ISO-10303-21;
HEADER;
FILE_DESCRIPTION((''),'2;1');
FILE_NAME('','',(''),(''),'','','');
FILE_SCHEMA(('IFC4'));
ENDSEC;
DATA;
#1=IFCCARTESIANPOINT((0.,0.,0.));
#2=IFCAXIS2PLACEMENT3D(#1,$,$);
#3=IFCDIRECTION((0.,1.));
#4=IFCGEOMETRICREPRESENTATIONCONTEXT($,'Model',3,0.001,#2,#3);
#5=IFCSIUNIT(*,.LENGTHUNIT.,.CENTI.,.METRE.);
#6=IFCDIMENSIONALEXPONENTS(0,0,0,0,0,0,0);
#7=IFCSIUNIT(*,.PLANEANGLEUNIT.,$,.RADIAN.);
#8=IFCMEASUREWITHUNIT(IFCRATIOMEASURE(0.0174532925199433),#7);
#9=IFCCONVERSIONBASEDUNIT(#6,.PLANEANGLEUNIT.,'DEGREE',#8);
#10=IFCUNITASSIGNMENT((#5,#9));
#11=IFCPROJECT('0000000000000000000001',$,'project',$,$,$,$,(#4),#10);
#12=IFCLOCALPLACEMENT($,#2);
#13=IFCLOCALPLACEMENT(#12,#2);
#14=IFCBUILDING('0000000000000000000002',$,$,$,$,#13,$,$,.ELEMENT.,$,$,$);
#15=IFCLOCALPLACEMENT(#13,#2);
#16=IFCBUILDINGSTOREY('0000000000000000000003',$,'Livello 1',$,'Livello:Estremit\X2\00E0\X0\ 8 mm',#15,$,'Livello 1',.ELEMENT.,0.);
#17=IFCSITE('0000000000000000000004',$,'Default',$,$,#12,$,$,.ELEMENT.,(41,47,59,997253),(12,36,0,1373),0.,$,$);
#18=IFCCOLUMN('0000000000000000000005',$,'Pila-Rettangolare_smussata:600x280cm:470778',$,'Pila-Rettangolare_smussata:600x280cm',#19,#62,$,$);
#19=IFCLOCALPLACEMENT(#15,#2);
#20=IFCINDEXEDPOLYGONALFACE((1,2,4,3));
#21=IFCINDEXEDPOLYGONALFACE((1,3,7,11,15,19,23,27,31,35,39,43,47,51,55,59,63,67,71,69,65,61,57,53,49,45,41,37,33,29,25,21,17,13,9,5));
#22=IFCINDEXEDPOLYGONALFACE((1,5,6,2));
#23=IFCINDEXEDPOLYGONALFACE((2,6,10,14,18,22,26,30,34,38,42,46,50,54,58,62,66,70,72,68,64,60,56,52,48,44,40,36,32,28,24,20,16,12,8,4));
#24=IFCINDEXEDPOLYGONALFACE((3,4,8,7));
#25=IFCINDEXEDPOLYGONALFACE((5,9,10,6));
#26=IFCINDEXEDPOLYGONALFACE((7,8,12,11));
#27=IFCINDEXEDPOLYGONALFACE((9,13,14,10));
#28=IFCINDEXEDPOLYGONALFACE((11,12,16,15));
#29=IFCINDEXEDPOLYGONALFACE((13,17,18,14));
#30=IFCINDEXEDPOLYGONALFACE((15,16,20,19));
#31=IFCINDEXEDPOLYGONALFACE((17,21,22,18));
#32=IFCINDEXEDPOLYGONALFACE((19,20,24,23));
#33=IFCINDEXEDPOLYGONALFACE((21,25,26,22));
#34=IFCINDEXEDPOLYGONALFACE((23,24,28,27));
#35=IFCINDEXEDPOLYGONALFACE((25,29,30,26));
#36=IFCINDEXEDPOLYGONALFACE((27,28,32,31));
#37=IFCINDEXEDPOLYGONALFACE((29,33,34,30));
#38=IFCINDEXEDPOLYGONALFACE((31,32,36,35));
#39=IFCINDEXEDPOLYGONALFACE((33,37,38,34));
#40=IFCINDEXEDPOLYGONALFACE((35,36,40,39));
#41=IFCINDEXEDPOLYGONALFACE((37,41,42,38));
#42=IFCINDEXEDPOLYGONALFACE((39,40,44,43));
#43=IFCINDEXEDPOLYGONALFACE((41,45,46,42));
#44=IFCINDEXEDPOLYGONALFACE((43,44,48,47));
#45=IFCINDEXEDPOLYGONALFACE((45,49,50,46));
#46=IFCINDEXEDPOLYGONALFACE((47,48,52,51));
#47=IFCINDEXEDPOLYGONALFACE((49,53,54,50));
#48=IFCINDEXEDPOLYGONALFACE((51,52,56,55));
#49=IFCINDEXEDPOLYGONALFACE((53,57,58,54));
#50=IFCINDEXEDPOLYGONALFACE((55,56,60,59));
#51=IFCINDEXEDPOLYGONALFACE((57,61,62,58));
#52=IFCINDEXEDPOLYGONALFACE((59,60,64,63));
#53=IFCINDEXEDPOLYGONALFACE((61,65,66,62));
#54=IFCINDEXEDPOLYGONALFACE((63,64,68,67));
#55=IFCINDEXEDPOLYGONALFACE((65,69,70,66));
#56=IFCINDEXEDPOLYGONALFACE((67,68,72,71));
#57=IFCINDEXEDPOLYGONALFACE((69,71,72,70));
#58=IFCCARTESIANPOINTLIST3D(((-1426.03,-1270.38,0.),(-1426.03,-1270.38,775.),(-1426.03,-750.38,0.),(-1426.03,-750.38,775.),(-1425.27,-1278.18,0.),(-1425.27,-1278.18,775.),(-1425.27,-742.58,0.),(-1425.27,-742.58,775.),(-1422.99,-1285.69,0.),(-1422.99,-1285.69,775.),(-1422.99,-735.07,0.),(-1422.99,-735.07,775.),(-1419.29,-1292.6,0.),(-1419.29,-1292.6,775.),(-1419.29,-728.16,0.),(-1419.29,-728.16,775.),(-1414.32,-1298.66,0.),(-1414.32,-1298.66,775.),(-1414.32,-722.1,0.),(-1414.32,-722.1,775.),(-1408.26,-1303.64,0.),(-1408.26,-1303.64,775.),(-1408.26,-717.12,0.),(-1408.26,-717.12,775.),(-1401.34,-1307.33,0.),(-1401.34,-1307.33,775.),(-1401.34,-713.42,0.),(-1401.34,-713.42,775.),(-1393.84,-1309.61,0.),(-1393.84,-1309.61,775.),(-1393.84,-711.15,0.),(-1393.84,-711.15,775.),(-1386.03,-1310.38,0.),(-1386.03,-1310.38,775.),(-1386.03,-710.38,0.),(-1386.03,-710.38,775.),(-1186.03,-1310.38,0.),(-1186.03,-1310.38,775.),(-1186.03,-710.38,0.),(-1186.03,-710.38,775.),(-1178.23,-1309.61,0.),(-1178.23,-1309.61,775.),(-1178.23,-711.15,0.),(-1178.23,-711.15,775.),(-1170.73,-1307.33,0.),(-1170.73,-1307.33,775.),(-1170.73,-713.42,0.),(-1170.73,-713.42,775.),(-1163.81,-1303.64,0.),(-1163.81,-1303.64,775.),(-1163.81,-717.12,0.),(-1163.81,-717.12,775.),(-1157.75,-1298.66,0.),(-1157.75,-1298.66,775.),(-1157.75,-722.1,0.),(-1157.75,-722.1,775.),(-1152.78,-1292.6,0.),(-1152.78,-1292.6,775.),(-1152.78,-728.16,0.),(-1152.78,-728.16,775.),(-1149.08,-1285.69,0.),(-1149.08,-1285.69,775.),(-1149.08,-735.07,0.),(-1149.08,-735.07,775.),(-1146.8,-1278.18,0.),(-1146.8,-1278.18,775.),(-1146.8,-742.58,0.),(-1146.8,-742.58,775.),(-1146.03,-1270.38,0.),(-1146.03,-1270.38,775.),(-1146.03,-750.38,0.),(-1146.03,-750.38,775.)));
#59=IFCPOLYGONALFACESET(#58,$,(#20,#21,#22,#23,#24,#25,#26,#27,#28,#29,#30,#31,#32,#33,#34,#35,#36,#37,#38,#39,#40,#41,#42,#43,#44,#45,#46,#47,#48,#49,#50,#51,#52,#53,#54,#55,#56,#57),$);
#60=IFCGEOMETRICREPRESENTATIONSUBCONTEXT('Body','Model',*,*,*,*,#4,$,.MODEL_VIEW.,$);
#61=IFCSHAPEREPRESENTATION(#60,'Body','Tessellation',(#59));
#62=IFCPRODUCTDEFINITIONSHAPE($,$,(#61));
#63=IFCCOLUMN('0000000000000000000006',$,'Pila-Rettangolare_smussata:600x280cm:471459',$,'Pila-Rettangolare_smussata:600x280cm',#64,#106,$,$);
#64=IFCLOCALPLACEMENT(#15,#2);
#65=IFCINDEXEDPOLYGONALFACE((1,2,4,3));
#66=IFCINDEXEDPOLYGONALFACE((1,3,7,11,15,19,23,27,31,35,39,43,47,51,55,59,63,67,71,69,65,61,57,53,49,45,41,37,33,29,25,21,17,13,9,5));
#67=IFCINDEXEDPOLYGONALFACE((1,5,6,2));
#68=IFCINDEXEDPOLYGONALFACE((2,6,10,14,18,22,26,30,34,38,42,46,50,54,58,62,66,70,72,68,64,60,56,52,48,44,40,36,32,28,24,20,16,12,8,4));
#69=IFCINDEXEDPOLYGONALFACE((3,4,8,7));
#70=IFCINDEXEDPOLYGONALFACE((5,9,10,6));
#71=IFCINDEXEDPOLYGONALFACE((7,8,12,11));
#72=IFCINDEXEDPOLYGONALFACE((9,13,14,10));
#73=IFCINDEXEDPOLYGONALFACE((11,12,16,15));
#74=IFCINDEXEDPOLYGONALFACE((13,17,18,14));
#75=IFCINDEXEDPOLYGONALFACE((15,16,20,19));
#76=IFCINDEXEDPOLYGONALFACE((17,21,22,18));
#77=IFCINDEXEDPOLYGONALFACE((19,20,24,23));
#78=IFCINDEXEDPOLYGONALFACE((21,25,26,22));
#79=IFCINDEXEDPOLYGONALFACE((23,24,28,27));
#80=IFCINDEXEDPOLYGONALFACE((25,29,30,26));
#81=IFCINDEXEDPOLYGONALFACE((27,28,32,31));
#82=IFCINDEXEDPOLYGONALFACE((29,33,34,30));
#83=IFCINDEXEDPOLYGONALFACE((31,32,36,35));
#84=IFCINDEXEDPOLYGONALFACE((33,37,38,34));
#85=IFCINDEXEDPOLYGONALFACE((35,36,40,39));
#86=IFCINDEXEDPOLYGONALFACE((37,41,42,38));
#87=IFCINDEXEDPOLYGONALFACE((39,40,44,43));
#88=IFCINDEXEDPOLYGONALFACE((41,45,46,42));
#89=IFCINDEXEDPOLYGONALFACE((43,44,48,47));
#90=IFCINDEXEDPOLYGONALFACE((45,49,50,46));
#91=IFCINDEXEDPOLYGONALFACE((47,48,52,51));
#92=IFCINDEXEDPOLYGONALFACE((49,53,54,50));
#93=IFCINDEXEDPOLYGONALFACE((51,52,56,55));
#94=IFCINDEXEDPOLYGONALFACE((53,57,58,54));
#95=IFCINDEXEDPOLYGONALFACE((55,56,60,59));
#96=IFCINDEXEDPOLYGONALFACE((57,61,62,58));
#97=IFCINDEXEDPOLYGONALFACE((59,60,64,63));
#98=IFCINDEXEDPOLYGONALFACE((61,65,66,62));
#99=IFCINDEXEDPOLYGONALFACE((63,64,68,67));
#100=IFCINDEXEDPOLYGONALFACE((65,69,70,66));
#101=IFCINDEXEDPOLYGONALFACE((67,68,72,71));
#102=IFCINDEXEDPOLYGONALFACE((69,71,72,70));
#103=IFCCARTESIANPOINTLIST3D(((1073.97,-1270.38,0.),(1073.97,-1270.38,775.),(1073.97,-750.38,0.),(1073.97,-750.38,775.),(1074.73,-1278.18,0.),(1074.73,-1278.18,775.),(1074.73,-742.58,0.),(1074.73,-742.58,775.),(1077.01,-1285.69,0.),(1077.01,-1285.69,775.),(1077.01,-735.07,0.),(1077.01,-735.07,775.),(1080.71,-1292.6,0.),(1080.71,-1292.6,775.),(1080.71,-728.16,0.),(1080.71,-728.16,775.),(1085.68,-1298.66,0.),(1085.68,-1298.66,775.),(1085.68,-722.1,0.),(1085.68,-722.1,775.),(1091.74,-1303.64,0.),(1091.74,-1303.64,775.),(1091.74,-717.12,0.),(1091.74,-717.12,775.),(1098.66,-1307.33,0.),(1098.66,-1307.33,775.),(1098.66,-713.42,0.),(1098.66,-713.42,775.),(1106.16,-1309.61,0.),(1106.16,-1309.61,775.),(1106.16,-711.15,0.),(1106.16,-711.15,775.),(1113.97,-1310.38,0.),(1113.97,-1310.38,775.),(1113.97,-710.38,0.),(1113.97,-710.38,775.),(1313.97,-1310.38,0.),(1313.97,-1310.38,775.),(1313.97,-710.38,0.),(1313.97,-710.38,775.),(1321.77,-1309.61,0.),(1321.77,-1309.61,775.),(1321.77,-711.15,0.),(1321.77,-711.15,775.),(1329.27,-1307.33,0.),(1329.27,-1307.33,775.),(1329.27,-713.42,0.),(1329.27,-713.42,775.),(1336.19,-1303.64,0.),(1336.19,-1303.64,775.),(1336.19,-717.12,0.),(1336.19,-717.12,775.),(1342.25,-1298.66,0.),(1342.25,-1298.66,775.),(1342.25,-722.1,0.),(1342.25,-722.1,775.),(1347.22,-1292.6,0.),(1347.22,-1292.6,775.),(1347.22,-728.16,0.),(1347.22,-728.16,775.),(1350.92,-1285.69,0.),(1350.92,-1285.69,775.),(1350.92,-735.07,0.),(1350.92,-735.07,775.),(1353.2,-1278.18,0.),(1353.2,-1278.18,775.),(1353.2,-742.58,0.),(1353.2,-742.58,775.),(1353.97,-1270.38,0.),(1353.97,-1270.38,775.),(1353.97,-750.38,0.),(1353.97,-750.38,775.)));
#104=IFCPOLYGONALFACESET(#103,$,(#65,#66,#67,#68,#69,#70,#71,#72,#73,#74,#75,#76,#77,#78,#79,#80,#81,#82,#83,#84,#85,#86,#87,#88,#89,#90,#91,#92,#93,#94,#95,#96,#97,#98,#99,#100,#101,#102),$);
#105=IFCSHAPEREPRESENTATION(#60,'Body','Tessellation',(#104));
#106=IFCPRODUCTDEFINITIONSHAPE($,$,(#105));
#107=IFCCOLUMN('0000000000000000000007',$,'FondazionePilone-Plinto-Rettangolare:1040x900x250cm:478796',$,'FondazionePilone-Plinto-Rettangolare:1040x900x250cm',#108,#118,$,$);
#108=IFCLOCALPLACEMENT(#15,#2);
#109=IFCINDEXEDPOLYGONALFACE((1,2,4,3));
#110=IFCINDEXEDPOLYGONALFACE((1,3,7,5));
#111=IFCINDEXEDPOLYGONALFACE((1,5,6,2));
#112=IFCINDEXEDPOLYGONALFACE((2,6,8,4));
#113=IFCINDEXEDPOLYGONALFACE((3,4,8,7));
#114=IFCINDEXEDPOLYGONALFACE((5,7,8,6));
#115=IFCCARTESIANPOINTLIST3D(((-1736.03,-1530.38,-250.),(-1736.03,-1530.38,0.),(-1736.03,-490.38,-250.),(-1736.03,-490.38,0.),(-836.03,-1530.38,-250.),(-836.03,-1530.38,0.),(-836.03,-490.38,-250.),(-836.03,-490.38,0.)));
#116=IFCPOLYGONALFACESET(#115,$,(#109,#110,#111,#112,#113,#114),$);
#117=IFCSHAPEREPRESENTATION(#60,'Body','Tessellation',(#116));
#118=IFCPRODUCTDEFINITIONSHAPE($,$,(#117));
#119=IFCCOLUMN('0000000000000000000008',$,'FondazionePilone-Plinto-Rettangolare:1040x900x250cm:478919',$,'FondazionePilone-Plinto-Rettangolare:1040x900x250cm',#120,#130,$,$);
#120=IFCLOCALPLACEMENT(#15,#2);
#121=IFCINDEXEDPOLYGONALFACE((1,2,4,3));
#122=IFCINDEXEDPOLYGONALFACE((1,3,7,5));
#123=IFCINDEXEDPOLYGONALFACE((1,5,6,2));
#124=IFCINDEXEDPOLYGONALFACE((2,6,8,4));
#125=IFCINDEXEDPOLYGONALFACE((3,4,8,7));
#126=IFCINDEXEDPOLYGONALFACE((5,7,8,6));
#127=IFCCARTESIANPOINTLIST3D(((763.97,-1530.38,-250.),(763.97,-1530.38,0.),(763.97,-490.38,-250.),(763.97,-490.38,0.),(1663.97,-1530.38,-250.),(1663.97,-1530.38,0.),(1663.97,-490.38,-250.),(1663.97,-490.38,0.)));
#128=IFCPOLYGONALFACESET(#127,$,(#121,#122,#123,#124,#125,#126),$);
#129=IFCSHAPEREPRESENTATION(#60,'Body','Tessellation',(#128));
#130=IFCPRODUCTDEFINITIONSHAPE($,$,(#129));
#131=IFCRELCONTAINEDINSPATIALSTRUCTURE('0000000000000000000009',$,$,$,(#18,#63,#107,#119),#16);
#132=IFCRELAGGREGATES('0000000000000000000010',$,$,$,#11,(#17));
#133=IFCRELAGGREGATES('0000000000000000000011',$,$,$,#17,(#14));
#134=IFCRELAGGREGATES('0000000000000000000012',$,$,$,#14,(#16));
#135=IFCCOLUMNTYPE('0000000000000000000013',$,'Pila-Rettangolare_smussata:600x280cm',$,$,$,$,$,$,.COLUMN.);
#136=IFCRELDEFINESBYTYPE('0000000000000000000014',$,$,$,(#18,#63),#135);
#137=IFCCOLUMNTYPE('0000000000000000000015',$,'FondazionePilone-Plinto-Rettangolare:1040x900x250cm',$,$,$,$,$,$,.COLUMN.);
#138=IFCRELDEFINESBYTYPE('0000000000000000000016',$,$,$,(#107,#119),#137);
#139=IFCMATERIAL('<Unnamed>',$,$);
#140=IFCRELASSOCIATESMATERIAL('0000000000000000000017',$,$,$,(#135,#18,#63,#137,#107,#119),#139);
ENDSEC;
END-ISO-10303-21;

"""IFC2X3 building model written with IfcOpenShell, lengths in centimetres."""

from ifc_helpers import new_model, entity, si_unit, converted_unit, direction, frame, frame_2d, origin, place, context, subcontext, project, spatial, polyline, circle_curve, parameter, trimmed, segment, composite_curve, rectangle, outline, extrude, source, transform, mapped, material, type_object, type_shapes, element, save


model = new_model("IFC2X3")

# Units and contexts
model_context = context("Model", 3, precision=0.001, world=origin(), true_north=direction((0.0, 1.0)))
body_context = subcontext(model_context, "Body", "Model", "MODEL_VIEW")
ifc_project = project(units=[si_unit("LENGTHUNIT", "METRE", prefix="CENTI"), converted_unit("PLANEANGLEUNIT", "DEGREE", entity("IfcRatioMeasure", 0.0174532925199433), si_unit("PLANEANGLEUNIT", "RADIAN"), dimensions=[0, 0, 0, 0, 0, 0, 0])], contexts=[model_context])

# Site, building, storey
site_placement = place(None, origin())
site = spatial("IfcSite", under=ifc_project, at=site_placement, Name="Default", CompositionType="ELEMENT", RefLatitude=(41, 47, 59, 997253), RefLongitude=(12, 36, 0, 1373), RefElevation=0.0)
building_placement = place(site_placement, origin())
building = spatial("IfcBuilding", under=site, at=building_placement, CompositionType="ELEMENT")
storey_placement = place(building_placement, origin())
storey = spatial("IfcBuildingStorey", under=building, at=storey_placement, Name="Livello 1", ObjectType="Livello:Estremità 8 mm", LongName="Livello 1", CompositionType="ELEMENT", Elevation=0.0)

# Columns
ifc_material = material(Name="<Unnamed>")
column_type_1 = type_object("IfcColumnType", Name="Pila-Rettangolare_smussata:600x280cm", PredefinedType="COLUMN", material=ifc_material)
shared_shape_1 = source(origin(), body_context, "Body", "SweptSolid", [
    extrude(outline(composite_curve([segment(polyline([(-100.0, -300.0), (100.0, -300.0)]), True, "CONTINUOUS"), segment(trimmed(circle_curve(frame_2d((100.0, -260.0), x_axis=(0.0, -1.0)), 40.0), [parameter(0.0)], [parameter(90.0)], True, "PARAMETER"), True, "CONTINUOUS"), segment(polyline([(140.0, -260.0), (140.0, 260.0)]), True, "CONTINUOUS"), segment(trimmed(circle_curve(frame_2d((100.0, 260.0), x_axis=(1.0, 0.0)), 40.0), [parameter(0.0)], [parameter(90.0)], True, "PARAMETER"), True, "CONTINUOUS"), segment(polyline([(100.0, 300.0), (-100.0, 300.0)]), True, "CONTINUOUS"), segment(trimmed(circle_curve(frame_2d((-100.0, 260.0), x_axis=(0.0, 1.0)), 40.0), [parameter(0.0)], [parameter(90.0)], True, "PARAMETER"), True, "CONTINUOUS"), segment(polyline([(-140.0, 260.0), (-140.0, -260.0)]), True, "CONTINUOUS"), segment(trimmed(circle_curve(frame_2d((-100.0, -260.0), x_axis=(-1.0, 0.0)), 40.0), [parameter(0.0)], [parameter(90.0)], True, "PARAMETER"), True, "CONTINUOUS")], self_intersect=False)), frame((0.0, 0.0, 0.0), z_axis=(0.0, 0.0, 1.0), x_axis=(0.0, -1.0, 0.0)), (0.0, 0.0, 1.0), 775.0),
])
type_shapes(column_type_1, [shared_shape_1])
for number, where, z_axis, x_axis, name in (
    (1, (-1286.03, -1010.38, 0.0), (0.0, 0.0, 1.0), (0.0, 1.0, 0.0), "Pila-Rettangolare_smussata:600x280cm:470778"),
    (2, (1213.97, -1010.38, 0.0), (0.0, 0.0, 1.0), (0.0, 1.0, 0.0), "Pila-Rettangolare_smussata:600x280cm:471459"),
):
    element("IfcColumn", number, at=place(storey_placement, frame(where, z_axis=z_axis, x_axis=x_axis)), inside=storey, type_object=column_type_1, material=ifc_material, Name=name, ObjectType="Pila-Rettangolare_smussata:600x280cm", context=body_context, shape_type="MappedRepresentation", body=[
        mapped(shared_shape_1, transform((0.0, 0.0, 0.0), scale=1.0)),
    ])
column_type_2 = type_object("IfcColumnType", Name="FondazionePilone-Plinto-Rettangolare:1040x900x250cm", PredefinedType="COLUMN", material=ifc_material)
shared_shape_2 = source(origin(), body_context, "Body", "SweptSolid", [
    extrude(rectangle(XDim=900.0, YDim=1040.0, at=frame_2d((0.0, 0.0), x_axis=(1.0, 0.0))), frame((0.0, 0.0, 0.0), z_axis=(0.0, 0.0, 1.0), x_axis=(0.0, -1.0, 0.0)), (0.0, 0.0, 1.0), 250.0),
])
type_shapes(column_type_2, [shared_shape_2])
for number, where, z_axis, x_axis, name in (
    (3, (-1286.03, -1010.38, -250.0), (0.0, 0.0, 1.0), (0.0, 1.0, 0.0), "FondazionePilone-Plinto-Rettangolare:1040x900x250cm:478796"),
    (4, (1213.97, -1010.38, -250.0), (0.0, 0.0, 1.0), (0.0, 1.0, 0.0), "FondazionePilone-Plinto-Rettangolare:1040x900x250cm:478919"),
):
    element("IfcColumn", number, at=place(storey_placement, frame(where, z_axis=z_axis, x_axis=x_axis)), inside=storey, type_object=column_type_2, material=ifc_material, Name=name, ObjectType="FondazionePilone-Plinto-Rettangolare:1040x900x250cm", context=body_context, shape_type="MappedRepresentation", body=[
        mapped(shared_shape_2, transform((0.0, 0.0, 0.0), scale=1.0)),
    ])

save(model, "model.ifc")
